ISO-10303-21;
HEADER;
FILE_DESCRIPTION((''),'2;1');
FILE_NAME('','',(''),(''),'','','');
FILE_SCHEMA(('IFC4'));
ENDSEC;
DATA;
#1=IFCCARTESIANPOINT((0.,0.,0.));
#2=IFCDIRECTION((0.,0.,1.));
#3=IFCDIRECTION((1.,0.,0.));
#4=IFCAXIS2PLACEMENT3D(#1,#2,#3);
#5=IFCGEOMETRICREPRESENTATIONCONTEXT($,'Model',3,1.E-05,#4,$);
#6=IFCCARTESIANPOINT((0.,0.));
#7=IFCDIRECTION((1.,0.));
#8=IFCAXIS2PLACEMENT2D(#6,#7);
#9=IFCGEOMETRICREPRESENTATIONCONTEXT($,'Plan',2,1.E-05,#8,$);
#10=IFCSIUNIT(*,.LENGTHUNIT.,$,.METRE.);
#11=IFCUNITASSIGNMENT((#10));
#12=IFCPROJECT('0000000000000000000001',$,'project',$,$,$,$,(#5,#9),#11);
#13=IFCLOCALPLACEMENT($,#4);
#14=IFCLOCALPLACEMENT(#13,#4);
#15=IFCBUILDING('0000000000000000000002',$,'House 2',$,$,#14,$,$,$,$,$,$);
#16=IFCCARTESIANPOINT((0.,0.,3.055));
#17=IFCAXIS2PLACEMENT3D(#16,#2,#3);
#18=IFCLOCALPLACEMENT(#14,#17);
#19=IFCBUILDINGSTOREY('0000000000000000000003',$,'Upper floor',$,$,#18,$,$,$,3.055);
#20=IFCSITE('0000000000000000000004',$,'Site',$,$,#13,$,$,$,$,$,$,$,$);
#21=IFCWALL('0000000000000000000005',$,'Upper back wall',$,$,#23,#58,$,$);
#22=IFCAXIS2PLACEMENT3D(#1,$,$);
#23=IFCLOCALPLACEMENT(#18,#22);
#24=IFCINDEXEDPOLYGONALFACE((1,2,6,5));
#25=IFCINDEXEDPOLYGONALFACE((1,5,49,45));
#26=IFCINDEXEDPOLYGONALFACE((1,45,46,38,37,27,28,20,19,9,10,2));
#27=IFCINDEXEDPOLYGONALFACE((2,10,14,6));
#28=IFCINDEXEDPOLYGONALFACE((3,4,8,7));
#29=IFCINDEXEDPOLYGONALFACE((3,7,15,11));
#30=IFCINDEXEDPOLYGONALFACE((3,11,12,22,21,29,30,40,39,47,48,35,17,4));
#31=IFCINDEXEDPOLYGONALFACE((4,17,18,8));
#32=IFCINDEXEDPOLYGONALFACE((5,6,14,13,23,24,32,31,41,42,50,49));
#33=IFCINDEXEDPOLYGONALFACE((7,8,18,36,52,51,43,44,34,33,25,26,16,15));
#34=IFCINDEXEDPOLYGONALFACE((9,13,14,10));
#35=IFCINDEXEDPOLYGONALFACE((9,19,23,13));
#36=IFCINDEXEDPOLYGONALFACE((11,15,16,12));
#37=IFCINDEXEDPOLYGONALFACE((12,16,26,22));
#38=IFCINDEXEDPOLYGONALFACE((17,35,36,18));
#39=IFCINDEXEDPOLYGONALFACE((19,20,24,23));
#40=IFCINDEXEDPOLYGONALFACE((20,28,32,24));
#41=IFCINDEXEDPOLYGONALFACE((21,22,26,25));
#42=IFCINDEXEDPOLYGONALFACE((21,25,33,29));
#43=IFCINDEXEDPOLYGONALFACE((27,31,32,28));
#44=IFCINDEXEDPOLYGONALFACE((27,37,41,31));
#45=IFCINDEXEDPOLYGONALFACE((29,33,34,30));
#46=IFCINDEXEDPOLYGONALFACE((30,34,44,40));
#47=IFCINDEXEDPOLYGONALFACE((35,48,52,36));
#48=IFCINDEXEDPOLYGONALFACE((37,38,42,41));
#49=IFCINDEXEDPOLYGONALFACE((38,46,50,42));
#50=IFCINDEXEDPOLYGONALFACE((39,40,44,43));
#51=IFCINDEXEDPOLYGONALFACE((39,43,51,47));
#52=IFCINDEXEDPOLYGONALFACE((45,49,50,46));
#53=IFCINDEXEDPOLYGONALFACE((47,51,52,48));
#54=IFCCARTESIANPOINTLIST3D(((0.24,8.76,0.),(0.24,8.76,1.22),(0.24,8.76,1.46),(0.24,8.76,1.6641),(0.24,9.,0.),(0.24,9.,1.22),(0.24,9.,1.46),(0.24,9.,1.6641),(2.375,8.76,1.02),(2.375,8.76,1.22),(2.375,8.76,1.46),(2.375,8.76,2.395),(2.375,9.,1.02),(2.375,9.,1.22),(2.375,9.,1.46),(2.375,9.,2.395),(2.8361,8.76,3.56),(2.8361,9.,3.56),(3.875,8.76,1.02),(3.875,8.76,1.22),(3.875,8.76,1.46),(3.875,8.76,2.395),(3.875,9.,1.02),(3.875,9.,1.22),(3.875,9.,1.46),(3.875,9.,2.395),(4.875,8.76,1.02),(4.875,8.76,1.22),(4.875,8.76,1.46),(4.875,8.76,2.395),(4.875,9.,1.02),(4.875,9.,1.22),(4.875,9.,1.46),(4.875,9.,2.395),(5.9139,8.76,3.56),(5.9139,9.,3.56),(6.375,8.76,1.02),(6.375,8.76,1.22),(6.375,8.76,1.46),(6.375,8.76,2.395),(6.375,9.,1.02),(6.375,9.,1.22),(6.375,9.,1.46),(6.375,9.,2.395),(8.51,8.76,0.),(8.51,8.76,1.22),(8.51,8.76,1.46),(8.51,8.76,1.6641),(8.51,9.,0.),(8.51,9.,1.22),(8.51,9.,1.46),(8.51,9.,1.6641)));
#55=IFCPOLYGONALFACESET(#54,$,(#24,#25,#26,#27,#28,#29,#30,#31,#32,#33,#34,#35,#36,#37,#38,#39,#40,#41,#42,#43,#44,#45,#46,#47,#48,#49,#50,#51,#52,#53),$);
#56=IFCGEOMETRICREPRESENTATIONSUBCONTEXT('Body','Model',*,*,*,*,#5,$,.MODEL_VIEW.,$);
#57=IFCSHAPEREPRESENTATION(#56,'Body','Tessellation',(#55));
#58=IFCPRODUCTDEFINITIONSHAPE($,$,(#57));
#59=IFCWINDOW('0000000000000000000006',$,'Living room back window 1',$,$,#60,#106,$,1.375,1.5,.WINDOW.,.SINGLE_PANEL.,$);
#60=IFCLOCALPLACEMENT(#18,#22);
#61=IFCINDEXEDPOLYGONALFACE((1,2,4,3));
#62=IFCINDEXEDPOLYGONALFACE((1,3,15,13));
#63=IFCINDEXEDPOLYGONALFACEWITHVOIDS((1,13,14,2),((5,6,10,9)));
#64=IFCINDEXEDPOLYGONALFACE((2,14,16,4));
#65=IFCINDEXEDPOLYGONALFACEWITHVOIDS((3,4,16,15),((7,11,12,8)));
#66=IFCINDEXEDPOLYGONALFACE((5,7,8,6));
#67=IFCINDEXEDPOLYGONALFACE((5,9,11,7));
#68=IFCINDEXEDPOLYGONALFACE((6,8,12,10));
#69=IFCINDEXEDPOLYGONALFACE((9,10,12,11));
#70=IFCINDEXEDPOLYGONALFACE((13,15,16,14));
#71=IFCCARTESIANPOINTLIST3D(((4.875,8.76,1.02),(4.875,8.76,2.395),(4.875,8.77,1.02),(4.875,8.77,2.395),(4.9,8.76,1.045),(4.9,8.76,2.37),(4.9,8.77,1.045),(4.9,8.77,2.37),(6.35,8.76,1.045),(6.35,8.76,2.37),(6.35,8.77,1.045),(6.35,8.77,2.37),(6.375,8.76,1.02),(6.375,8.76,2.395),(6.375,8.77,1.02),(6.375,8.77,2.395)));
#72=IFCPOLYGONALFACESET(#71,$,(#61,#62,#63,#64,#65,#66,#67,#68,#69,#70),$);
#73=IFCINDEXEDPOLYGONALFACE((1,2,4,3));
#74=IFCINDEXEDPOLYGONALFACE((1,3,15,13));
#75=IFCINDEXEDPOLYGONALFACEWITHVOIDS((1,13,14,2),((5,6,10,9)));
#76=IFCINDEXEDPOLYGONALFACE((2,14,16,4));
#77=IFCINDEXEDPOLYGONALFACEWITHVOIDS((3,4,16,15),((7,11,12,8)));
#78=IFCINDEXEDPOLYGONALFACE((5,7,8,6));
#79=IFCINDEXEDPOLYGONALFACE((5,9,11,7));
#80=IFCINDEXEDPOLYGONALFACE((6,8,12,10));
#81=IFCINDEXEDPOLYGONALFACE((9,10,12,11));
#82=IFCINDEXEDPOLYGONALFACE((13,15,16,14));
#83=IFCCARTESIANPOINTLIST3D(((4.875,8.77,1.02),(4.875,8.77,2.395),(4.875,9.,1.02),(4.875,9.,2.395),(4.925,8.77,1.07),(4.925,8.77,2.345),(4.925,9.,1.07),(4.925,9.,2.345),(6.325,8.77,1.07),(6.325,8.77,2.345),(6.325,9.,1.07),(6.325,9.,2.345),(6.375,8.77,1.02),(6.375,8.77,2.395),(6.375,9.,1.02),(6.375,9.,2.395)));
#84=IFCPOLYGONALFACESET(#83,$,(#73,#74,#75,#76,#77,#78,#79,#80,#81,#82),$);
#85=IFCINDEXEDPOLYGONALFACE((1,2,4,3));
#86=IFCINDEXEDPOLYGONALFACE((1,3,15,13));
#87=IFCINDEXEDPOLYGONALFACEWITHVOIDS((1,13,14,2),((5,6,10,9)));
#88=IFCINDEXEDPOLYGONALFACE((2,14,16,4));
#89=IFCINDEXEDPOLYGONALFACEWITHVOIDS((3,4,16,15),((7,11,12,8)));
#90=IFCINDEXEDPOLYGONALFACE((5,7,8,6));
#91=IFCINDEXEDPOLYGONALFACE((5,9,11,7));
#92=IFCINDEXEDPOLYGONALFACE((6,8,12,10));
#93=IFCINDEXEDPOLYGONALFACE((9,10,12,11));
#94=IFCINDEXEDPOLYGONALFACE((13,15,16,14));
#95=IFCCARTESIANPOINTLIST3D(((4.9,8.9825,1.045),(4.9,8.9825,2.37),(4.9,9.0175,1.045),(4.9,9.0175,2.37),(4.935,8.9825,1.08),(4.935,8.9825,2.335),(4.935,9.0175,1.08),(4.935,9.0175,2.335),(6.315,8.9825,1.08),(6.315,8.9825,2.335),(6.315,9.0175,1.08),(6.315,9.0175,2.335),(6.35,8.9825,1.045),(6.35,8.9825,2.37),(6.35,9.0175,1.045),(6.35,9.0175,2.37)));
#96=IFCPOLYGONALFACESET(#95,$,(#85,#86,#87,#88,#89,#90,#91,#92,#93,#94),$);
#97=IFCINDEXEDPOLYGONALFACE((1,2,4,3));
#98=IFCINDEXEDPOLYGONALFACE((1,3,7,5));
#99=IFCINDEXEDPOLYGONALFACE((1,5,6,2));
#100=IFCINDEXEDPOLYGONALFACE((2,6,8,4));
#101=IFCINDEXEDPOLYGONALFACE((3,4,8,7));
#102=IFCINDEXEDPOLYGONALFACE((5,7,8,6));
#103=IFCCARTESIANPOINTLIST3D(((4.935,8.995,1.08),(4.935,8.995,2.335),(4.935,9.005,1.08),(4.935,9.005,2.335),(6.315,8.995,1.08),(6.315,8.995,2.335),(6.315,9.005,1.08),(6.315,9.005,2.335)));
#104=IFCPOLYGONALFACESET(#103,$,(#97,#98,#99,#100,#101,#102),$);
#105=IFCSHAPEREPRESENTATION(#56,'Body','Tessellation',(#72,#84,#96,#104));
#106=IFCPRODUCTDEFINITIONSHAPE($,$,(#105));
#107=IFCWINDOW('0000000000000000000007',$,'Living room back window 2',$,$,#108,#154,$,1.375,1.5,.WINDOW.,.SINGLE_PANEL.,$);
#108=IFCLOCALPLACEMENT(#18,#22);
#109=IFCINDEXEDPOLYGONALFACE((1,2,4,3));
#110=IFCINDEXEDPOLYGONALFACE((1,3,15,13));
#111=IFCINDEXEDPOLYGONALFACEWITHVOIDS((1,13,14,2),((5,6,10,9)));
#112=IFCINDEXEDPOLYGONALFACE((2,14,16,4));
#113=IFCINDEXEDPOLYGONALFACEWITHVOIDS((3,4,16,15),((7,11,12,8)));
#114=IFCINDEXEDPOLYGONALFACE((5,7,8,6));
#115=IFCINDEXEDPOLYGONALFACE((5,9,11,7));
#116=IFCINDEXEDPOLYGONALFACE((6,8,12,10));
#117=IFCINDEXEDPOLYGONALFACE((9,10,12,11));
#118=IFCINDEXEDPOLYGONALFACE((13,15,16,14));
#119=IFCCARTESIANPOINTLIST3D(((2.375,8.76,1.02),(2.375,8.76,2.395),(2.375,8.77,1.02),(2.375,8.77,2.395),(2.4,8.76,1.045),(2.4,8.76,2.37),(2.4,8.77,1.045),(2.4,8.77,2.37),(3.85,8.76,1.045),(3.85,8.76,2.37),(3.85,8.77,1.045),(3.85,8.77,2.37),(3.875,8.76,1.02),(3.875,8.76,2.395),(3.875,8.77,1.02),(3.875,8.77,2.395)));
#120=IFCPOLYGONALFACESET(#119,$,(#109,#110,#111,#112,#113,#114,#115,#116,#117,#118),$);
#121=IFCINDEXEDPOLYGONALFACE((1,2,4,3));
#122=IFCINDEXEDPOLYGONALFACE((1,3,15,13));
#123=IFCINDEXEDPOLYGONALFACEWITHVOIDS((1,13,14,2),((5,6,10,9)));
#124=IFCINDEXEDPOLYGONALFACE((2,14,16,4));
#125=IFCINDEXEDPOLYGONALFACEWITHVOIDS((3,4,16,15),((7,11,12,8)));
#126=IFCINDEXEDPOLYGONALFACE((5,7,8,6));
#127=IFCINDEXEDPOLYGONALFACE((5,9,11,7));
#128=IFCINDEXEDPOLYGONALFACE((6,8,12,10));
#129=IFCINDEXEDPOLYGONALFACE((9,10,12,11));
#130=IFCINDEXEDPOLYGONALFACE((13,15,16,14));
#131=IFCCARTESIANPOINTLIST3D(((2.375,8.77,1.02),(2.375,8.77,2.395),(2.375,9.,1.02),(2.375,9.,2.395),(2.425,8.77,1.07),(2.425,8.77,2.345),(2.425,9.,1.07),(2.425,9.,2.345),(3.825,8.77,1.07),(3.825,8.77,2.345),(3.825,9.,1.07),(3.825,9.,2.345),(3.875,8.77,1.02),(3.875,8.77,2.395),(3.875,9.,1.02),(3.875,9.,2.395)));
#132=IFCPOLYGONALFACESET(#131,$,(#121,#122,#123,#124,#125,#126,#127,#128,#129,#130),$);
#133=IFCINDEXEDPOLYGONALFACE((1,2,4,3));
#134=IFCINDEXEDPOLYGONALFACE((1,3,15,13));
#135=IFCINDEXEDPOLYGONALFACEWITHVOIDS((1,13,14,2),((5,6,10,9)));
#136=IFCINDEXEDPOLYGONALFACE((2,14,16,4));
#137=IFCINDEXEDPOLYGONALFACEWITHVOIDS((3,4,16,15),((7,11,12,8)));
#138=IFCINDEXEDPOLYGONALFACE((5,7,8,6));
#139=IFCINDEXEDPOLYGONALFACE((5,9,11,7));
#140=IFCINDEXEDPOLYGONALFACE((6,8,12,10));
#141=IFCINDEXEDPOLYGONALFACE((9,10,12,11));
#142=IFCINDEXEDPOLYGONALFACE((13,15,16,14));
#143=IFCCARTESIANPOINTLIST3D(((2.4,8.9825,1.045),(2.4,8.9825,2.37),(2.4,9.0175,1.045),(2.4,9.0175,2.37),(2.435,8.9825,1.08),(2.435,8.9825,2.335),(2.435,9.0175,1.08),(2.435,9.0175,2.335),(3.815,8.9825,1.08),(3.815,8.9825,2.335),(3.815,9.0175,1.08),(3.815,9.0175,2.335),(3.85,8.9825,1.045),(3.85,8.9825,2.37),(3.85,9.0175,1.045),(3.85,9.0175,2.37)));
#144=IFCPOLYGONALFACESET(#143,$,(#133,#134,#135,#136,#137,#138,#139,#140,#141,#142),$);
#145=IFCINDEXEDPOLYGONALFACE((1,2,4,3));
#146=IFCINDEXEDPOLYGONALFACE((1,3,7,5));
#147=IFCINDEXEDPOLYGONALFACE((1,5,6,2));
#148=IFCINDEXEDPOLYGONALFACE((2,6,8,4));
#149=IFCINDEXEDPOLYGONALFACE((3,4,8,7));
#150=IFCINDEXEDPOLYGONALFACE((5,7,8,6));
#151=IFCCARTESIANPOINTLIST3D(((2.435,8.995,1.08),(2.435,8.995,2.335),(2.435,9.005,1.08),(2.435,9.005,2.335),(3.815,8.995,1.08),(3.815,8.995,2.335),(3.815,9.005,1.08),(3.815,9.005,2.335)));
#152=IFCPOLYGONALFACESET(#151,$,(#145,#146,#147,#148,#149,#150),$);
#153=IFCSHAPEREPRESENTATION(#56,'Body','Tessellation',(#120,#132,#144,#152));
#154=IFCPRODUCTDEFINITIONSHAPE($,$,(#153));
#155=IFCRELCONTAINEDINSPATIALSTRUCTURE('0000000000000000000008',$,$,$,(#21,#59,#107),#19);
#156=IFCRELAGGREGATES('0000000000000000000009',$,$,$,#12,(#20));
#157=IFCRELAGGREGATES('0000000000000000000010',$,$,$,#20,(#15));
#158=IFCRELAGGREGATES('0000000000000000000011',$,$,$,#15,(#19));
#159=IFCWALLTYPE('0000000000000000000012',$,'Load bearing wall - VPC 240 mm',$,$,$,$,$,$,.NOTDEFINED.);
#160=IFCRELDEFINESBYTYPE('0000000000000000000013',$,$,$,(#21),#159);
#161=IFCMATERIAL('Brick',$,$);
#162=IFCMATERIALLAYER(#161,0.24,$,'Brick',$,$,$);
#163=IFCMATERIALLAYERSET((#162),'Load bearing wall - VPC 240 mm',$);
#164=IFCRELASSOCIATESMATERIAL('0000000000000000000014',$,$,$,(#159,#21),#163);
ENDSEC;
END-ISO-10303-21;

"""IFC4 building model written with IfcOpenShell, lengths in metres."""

from ifc_helpers import new_model, entity, si_unit, frame, origin_with_axes, origin_2d_with_axis, place, context, subcontext, project, spatial, line, indexed_curve, outline, extrude, boolean, clip, halfspace, shape, material, layer, layer_set, layer_usage, type_object, element, fill, save


model = new_model("IFC4")

# Units and contexts
model_context = context("Model", 3, precision=1e-05, world=origin_with_axes())
plan_context = context("Plan", 2, precision=1e-05, world=origin_2d_with_axis())
body_context_1 = subcontext(model_context, "Body", "Model", "MODEL_VIEW")
body_context_2 = subcontext(plan_context, "Body", "Plan", "PLAN_VIEW")
ifc_project = project(units=[si_unit("LENGTHUNIT", "METRE")], contexts=[model_context, plan_context])

# Site, building, storey
site_placement = place(None, origin_with_axes())
site = spatial("IfcSite", under=ifc_project, at=site_placement, Name="Site")
building_placement = place(site_placement, origin_with_axes())
building = spatial("IfcBuilding", under=site, at=building_placement, Name="House 2")
storey_placement = place(building_placement, frame((0.0, 0.0, 3.055), z_axis=(0.0, 0.0, 1.0), x_axis=(1.0, 0.0, 0.0)))
storey = spatial("IfcBuildingStorey", under=building, at=storey_placement, Name="Upper floor", Elevation=3.055)

# Wall, openings, windows
ifc_material_1 = material(Name="Brick")
ifc_layer = layer(ifc_material_1, 0.24, Name="Brick")
ifc_layer_set = layer_set([ifc_layer], Name="Load bearing wall - VPC 240 mm")
ifc_layer_usage = layer_usage(ifc_layer_set, "AXIS2", "NEGATIVE", 0.24)
wall_type = type_object("IfcWallType", Name="Load bearing wall - VPC 240 mm", PredefinedType="NOTDEFINED", material=ifc_layer_set)
wall_placement = place(storey_placement, frame((8.51, 9.0, 0.0), z_axis=(0.0, 0.0, 1.0), x_axis=(-1.0, 0.0, 0.0)))
wall = element("IfcWall", 1, at=wall_placement, inside=storey, type_object=wall_type, material=ifc_layer_usage, Name="Upper back wall", context=body_context_1, shape_type="CSG", body=[
    boolean("DIFFERENCE", boolean("DIFFERENCE", boolean("DIFFERENCE", clip(clip(clip(extrude(outline(indexed_curve([(0.0, 0.0), (0.0, 0.24), (8.27, 0.24), (8.27, 0.0), (0.0, 0.0)], self_intersect=False)), origin_with_axes(), (0.0, 0.0, 1.0), 3.56), halfspace(frame((8.4405, 9.0, 1.5396), z_axis=(0.58975, 0.0, 0.807586), x_axis=(0.0, -1.0, 0.0)), False)), halfspace(frame((-0.1705, 9.0, 1.5396), z_axis=(-0.58975, 0.0, 0.807586), x_axis=(0.0, 1.0, 0.0)), False)), halfspace(frame((8.51, 9.0, 3.56), z_axis=(0.0, 0.0, 1.0), x_axis=(-1.0, 0.0, 0.0)), False)), extrude(outline(indexed_curve([(0.0, 0.0), (2.145, 0.0), (2.145, 0.24), (0.0, 0.24)], segments=[line(1, 2, 3, 4, 1)])), frame((-0.01, 0.0, 1.22), z_axis=(0.0, 0.0, 1.0), x_axis=(1.0, 0.0, 0.0)), (0.0, 0.0, 1.0), 0.24)), extrude(outline(indexed_curve([(0.0, 0.0), (1.0, 0.0), (1.0, 0.24), (0.0, 0.24)], segments=[line(1, 2, 3, 4, 1)])), frame((3.635, 0.0, 1.22), z_axis=(0.0, 0.0, 1.0), x_axis=(1.0, 0.0, 0.0)), (0.0, 0.0, 1.0), 0.24)), extrude(outline(indexed_curve([(0.0, 0.0), (2.145, 0.0), (2.145, 0.24), (0.0, 0.24)], segments=[line(1, 2, 3, 4, 1)])), frame((6.135, 0.0, 1.22), z_axis=(0.0, 0.0, 1.0), x_axis=(1.0, 0.0, 0.0)), (0.0, 0.0, 1.0), 0.24)),
])
opening_1_placement = place(wall_placement, frame((2.135, 0.0, 1.02), z_axis=(0.0, 0.0, 1.0), x_axis=(1.0, 0.0, 0.0)))
opening_1 = element("IfcOpeningElement", 2, at=opening_1_placement, cuts=wall, PredefinedType="OPENING", context=body_context_1, shape_type="SweptSolid", body=[
    extrude(outline(indexed_curve([(0.0, 0.0), (0.0, 0.34), (1.5, 0.34), (1.5, 0.0), (0.0, 0.0)], self_intersect=False)), frame((0.0, -0.05, 0.0), z_axis=(0.0, 0.0, 1.0), x_axis=(1.0, 0.0, 0.0)), (0.0, 0.0, 1.0), 1.375),
])
opening_2_placement = place(wall_placement, frame((4.635, 0.0, 1.02), z_axis=(0.0, 0.0, 1.0), x_axis=(1.0, 0.0, 0.0)))
opening_2 = element("IfcOpeningElement", 3, at=opening_2_placement, cuts=wall, PredefinedType="OPENING", context=body_context_1, shape_type="SweptSolid", body=[
    extrude(outline(indexed_curve([(0.0, 0.0), (0.0, 0.34), (1.5, 0.34), (1.5, 0.0), (0.0, 0.0)], self_intersect=False)), frame((0.0, -0.05, 0.0), z_axis=(0.0, 0.0, 1.0), x_axis=(1.0, 0.0, 0.0)), (0.0, 0.0, 1.0), 1.375),
])
window_1_placement = place(opening_1_placement, frame((0.0, 0.0, 0.0), z_axis=(0.0, 0.0, 1.0), x_axis=(1.0, 0.0, 0.0)))
window_1 = element("IfcWindow", 4, at=window_1_placement, inside=storey, Name="Living room back window 1", OverallHeight=1.375, OverallWidth=1.5, PartitioningType="SINGLE_PANEL", PredefinedType="WINDOW", shapes=[
    shape(body_context_1, "Body", "SweptSolid", [extrude(outline(indexed_curve([(0.0, 0.0), (1.5, 0.0), (1.5, 1.375), (0.0, 1.375)], segments=[line(1, 2, 3, 4, 1)]), holes=[indexed_curve([(0.025, 0.025), (1.475, 0.025), (1.475, 1.35), (0.025, 1.35)], segments=[line(1, 2, 3, 4, 1)])]), frame((0.0, 0.23, 0.0), z_axis=(0.0, -1.0, 0.0), x_axis=(1.0, 0.0, 0.0)), (0.0, 0.0, -1.0), 0.01), extrude(outline(indexed_curve([(0.0, 0.0), (1.5, 0.0), (1.5, 1.375), (0.0, 1.375)], segments=[line(1, 2, 3, 4, 1)]), holes=[indexed_curve([(0.05, 0.05), (1.45, 0.05), (1.45, 1.325), (0.05, 1.325)], segments=[line(1, 2, 3, 4, 1)])]), frame((0.0, 0.0, 0.0), z_axis=(0.0, -1.0, 0.0), x_axis=(1.0, 0.0, 0.0)), (0.0, 0.0, -1.0), 0.23), extrude(outline(indexed_curve([(0.0, 0.0), (1.45, 0.0), (1.45, 1.325), (0.0, 1.325)], segments=[line(1, 2, 3, 4, 1)]), holes=[indexed_curve([(0.035, 0.035), (1.415, 0.035), (1.415, 1.29), (0.035, 1.29)], segments=[line(1, 2, 3, 4, 1)])]), frame((0.025, -0.0175, 0.025), z_axis=(0.0, -1.0, 0.0), x_axis=(1.0, 0.0, 0.0)), (0.0, 0.0, -1.0), 0.035), extrude(outline(indexed_curve([(0.035, 0.035), (1.415, 0.035), (1.415, 1.29), (0.035, 1.29)], segments=[line(1, 2, 3, 4, 1)])), frame((0.025, -0.005, 0.025), z_axis=(0.0, -1.0, 0.0), x_axis=(1.0, 0.0, 0.0)), (0.0, 0.0, -1.0), 0.01)]),
    shape(body_context_2, "Body", "Curve2D", [entity("IfcIndexedPolyCurve", entity("IfcCartesianPointList2D", [[0.05, 0.0], [1.45, 0.0]])), entity("IfcIndexedPolyCurve", entity("IfcCartesianPointList2D", [[0.0, 0.24], [0.025, 0.24], [0.025, 0.23], [0.05, 0.23], [0.05, 0.0], [0.0, 0.0]]), [entity("IfcLineIndex", [1, 2, 3, 4, 5, 6, 1])]), entity("IfcIndexedPolyCurve", entity("IfcCartesianPointList2D", [[1.5, 0.24], [1.475, 0.24], [1.475, 0.23], [1.45, 0.23], [1.45, 0.0], [1.5, 0.0]]), [entity("IfcLineIndex", [1, 2, 3, 4, 5, 6, 1])]), entity("IfcIndexedPolyCurve", entity("IfcCartesianPointList2D", [[0.025, -0.0175], [0.06, -0.0175], [0.06, 0.0175], [0.025, 0.0175]]), [entity("IfcLineIndex", [1, 2, 3, 4, 1])]), entity("IfcIndexedPolyCurve", entity("IfcCartesianPointList2D", [[1.475, -0.0175], [1.44, -0.0175], [1.44, 0.0175], [1.475, 0.0175]]), [entity("IfcLineIndex", [1, 2, 3, 4, 1])]), entity("IfcIndexedPolyCurve", entity("IfcCartesianPointList2D", [[0.06, -0.0175], [1.44, -0.0175]])), entity("IfcIndexedPolyCurve", entity("IfcCartesianPointList2D", [[0.06, 0.0175], [1.44, 0.0175]])), entity("IfcIndexedPolyCurve", entity("IfcCartesianPointList2D", [[0.06, 0.0], [1.44, 0.0]]))]),
])
fill(opening_1, window_1)
window_2_placement = place(opening_2_placement, frame((0.0, 0.0, 0.0), z_axis=(0.0, 0.0, 1.0), x_axis=(1.0, 0.0, 0.0)))
window_2 = element("IfcWindow", 5, at=window_2_placement, inside=storey, Name="Living room back window 2", OverallHeight=1.375, OverallWidth=1.5, PartitioningType="SINGLE_PANEL", PredefinedType="WINDOW", shapes=[
    shape(body_context_1, "Body", "SweptSolid", [extrude(outline(indexed_curve([(0.0, 0.0), (1.5, 0.0), (1.5, 1.375), (0.0, 1.375)], segments=[line(1, 2, 3, 4, 1)]), holes=[indexed_curve([(0.025, 0.025), (1.475, 0.025), (1.475, 1.35), (0.025, 1.35)], segments=[line(1, 2, 3, 4, 1)])]), frame((0.0, 0.23, 0.0), z_axis=(0.0, -1.0, 0.0), x_axis=(1.0, 0.0, 0.0)), (0.0, 0.0, -1.0), 0.01), extrude(outline(indexed_curve([(0.0, 0.0), (1.5, 0.0), (1.5, 1.375), (0.0, 1.375)], segments=[line(1, 2, 3, 4, 1)]), holes=[indexed_curve([(0.05, 0.05), (1.45, 0.05), (1.45, 1.325), (0.05, 1.325)], segments=[line(1, 2, 3, 4, 1)])]), frame((0.0, 0.0, 0.0), z_axis=(0.0, -1.0, 0.0), x_axis=(1.0, 0.0, 0.0)), (0.0, 0.0, -1.0), 0.23), extrude(outline(indexed_curve([(0.0, 0.0), (1.45, 0.0), (1.45, 1.325), (0.0, 1.325)], segments=[line(1, 2, 3, 4, 1)]), holes=[indexed_curve([(0.035, 0.035), (1.415, 0.035), (1.415, 1.29), (0.035, 1.29)], segments=[line(1, 2, 3, 4, 1)])]), frame((0.025, -0.0175, 0.025), z_axis=(0.0, -1.0, 0.0), x_axis=(1.0, 0.0, 0.0)), (0.0, 0.0, -1.0), 0.035), extrude(outline(indexed_curve([(0.035, 0.035), (1.415, 0.035), (1.415, 1.29), (0.035, 1.29)], segments=[line(1, 2, 3, 4, 1)])), frame((0.025, -0.005, 0.025), z_axis=(0.0, -1.0, 0.0), x_axis=(1.0, 0.0, 0.0)), (0.0, 0.0, -1.0), 0.01)]),
    shape(body_context_2, "Body", "Curve2D", [entity("IfcIndexedPolyCurve", entity("IfcCartesianPointList2D", [[0.05, 0.0], [1.45, 0.0]])), entity("IfcIndexedPolyCurve", entity("IfcCartesianPointList2D", [[0.0, 0.24], [0.025, 0.24], [0.025, 0.23], [0.05, 0.23], [0.05, 0.0], [0.0, 0.0]]), [entity("IfcLineIndex", [1, 2, 3, 4, 5, 6, 1])]), entity("IfcIndexedPolyCurve", entity("IfcCartesianPointList2D", [[1.5, 0.24], [1.475, 0.24], [1.475, 0.23], [1.45, 0.23], [1.45, 0.0], [1.5, 0.0]]), [entity("IfcLineIndex", [1, 2, 3, 4, 5, 6, 1])]), entity("IfcIndexedPolyCurve", entity("IfcCartesianPointList2D", [[0.025, -0.0175], [0.06, -0.0175], [0.06, 0.0175], [0.025, 0.0175]]), [entity("IfcLineIndex", [1, 2, 3, 4, 1])]), entity("IfcIndexedPolyCurve", entity("IfcCartesianPointList2D", [[1.475, -0.0175], [1.44, -0.0175], [1.44, 0.0175], [1.475, 0.0175]]), [entity("IfcLineIndex", [1, 2, 3, 4, 1])]), entity("IfcIndexedPolyCurve", entity("IfcCartesianPointList2D", [[0.06, -0.0175], [1.44, -0.0175]])), entity("IfcIndexedPolyCurve", entity("IfcCartesianPointList2D", [[0.06, 0.0175], [1.44, 0.0175]])), entity("IfcIndexedPolyCurve", entity("IfcCartesianPointList2D", [[0.06, 0.0], [1.44, 0.0]]))]),
])
fill(opening_2, window_2)

save(model, "model.ifc")
